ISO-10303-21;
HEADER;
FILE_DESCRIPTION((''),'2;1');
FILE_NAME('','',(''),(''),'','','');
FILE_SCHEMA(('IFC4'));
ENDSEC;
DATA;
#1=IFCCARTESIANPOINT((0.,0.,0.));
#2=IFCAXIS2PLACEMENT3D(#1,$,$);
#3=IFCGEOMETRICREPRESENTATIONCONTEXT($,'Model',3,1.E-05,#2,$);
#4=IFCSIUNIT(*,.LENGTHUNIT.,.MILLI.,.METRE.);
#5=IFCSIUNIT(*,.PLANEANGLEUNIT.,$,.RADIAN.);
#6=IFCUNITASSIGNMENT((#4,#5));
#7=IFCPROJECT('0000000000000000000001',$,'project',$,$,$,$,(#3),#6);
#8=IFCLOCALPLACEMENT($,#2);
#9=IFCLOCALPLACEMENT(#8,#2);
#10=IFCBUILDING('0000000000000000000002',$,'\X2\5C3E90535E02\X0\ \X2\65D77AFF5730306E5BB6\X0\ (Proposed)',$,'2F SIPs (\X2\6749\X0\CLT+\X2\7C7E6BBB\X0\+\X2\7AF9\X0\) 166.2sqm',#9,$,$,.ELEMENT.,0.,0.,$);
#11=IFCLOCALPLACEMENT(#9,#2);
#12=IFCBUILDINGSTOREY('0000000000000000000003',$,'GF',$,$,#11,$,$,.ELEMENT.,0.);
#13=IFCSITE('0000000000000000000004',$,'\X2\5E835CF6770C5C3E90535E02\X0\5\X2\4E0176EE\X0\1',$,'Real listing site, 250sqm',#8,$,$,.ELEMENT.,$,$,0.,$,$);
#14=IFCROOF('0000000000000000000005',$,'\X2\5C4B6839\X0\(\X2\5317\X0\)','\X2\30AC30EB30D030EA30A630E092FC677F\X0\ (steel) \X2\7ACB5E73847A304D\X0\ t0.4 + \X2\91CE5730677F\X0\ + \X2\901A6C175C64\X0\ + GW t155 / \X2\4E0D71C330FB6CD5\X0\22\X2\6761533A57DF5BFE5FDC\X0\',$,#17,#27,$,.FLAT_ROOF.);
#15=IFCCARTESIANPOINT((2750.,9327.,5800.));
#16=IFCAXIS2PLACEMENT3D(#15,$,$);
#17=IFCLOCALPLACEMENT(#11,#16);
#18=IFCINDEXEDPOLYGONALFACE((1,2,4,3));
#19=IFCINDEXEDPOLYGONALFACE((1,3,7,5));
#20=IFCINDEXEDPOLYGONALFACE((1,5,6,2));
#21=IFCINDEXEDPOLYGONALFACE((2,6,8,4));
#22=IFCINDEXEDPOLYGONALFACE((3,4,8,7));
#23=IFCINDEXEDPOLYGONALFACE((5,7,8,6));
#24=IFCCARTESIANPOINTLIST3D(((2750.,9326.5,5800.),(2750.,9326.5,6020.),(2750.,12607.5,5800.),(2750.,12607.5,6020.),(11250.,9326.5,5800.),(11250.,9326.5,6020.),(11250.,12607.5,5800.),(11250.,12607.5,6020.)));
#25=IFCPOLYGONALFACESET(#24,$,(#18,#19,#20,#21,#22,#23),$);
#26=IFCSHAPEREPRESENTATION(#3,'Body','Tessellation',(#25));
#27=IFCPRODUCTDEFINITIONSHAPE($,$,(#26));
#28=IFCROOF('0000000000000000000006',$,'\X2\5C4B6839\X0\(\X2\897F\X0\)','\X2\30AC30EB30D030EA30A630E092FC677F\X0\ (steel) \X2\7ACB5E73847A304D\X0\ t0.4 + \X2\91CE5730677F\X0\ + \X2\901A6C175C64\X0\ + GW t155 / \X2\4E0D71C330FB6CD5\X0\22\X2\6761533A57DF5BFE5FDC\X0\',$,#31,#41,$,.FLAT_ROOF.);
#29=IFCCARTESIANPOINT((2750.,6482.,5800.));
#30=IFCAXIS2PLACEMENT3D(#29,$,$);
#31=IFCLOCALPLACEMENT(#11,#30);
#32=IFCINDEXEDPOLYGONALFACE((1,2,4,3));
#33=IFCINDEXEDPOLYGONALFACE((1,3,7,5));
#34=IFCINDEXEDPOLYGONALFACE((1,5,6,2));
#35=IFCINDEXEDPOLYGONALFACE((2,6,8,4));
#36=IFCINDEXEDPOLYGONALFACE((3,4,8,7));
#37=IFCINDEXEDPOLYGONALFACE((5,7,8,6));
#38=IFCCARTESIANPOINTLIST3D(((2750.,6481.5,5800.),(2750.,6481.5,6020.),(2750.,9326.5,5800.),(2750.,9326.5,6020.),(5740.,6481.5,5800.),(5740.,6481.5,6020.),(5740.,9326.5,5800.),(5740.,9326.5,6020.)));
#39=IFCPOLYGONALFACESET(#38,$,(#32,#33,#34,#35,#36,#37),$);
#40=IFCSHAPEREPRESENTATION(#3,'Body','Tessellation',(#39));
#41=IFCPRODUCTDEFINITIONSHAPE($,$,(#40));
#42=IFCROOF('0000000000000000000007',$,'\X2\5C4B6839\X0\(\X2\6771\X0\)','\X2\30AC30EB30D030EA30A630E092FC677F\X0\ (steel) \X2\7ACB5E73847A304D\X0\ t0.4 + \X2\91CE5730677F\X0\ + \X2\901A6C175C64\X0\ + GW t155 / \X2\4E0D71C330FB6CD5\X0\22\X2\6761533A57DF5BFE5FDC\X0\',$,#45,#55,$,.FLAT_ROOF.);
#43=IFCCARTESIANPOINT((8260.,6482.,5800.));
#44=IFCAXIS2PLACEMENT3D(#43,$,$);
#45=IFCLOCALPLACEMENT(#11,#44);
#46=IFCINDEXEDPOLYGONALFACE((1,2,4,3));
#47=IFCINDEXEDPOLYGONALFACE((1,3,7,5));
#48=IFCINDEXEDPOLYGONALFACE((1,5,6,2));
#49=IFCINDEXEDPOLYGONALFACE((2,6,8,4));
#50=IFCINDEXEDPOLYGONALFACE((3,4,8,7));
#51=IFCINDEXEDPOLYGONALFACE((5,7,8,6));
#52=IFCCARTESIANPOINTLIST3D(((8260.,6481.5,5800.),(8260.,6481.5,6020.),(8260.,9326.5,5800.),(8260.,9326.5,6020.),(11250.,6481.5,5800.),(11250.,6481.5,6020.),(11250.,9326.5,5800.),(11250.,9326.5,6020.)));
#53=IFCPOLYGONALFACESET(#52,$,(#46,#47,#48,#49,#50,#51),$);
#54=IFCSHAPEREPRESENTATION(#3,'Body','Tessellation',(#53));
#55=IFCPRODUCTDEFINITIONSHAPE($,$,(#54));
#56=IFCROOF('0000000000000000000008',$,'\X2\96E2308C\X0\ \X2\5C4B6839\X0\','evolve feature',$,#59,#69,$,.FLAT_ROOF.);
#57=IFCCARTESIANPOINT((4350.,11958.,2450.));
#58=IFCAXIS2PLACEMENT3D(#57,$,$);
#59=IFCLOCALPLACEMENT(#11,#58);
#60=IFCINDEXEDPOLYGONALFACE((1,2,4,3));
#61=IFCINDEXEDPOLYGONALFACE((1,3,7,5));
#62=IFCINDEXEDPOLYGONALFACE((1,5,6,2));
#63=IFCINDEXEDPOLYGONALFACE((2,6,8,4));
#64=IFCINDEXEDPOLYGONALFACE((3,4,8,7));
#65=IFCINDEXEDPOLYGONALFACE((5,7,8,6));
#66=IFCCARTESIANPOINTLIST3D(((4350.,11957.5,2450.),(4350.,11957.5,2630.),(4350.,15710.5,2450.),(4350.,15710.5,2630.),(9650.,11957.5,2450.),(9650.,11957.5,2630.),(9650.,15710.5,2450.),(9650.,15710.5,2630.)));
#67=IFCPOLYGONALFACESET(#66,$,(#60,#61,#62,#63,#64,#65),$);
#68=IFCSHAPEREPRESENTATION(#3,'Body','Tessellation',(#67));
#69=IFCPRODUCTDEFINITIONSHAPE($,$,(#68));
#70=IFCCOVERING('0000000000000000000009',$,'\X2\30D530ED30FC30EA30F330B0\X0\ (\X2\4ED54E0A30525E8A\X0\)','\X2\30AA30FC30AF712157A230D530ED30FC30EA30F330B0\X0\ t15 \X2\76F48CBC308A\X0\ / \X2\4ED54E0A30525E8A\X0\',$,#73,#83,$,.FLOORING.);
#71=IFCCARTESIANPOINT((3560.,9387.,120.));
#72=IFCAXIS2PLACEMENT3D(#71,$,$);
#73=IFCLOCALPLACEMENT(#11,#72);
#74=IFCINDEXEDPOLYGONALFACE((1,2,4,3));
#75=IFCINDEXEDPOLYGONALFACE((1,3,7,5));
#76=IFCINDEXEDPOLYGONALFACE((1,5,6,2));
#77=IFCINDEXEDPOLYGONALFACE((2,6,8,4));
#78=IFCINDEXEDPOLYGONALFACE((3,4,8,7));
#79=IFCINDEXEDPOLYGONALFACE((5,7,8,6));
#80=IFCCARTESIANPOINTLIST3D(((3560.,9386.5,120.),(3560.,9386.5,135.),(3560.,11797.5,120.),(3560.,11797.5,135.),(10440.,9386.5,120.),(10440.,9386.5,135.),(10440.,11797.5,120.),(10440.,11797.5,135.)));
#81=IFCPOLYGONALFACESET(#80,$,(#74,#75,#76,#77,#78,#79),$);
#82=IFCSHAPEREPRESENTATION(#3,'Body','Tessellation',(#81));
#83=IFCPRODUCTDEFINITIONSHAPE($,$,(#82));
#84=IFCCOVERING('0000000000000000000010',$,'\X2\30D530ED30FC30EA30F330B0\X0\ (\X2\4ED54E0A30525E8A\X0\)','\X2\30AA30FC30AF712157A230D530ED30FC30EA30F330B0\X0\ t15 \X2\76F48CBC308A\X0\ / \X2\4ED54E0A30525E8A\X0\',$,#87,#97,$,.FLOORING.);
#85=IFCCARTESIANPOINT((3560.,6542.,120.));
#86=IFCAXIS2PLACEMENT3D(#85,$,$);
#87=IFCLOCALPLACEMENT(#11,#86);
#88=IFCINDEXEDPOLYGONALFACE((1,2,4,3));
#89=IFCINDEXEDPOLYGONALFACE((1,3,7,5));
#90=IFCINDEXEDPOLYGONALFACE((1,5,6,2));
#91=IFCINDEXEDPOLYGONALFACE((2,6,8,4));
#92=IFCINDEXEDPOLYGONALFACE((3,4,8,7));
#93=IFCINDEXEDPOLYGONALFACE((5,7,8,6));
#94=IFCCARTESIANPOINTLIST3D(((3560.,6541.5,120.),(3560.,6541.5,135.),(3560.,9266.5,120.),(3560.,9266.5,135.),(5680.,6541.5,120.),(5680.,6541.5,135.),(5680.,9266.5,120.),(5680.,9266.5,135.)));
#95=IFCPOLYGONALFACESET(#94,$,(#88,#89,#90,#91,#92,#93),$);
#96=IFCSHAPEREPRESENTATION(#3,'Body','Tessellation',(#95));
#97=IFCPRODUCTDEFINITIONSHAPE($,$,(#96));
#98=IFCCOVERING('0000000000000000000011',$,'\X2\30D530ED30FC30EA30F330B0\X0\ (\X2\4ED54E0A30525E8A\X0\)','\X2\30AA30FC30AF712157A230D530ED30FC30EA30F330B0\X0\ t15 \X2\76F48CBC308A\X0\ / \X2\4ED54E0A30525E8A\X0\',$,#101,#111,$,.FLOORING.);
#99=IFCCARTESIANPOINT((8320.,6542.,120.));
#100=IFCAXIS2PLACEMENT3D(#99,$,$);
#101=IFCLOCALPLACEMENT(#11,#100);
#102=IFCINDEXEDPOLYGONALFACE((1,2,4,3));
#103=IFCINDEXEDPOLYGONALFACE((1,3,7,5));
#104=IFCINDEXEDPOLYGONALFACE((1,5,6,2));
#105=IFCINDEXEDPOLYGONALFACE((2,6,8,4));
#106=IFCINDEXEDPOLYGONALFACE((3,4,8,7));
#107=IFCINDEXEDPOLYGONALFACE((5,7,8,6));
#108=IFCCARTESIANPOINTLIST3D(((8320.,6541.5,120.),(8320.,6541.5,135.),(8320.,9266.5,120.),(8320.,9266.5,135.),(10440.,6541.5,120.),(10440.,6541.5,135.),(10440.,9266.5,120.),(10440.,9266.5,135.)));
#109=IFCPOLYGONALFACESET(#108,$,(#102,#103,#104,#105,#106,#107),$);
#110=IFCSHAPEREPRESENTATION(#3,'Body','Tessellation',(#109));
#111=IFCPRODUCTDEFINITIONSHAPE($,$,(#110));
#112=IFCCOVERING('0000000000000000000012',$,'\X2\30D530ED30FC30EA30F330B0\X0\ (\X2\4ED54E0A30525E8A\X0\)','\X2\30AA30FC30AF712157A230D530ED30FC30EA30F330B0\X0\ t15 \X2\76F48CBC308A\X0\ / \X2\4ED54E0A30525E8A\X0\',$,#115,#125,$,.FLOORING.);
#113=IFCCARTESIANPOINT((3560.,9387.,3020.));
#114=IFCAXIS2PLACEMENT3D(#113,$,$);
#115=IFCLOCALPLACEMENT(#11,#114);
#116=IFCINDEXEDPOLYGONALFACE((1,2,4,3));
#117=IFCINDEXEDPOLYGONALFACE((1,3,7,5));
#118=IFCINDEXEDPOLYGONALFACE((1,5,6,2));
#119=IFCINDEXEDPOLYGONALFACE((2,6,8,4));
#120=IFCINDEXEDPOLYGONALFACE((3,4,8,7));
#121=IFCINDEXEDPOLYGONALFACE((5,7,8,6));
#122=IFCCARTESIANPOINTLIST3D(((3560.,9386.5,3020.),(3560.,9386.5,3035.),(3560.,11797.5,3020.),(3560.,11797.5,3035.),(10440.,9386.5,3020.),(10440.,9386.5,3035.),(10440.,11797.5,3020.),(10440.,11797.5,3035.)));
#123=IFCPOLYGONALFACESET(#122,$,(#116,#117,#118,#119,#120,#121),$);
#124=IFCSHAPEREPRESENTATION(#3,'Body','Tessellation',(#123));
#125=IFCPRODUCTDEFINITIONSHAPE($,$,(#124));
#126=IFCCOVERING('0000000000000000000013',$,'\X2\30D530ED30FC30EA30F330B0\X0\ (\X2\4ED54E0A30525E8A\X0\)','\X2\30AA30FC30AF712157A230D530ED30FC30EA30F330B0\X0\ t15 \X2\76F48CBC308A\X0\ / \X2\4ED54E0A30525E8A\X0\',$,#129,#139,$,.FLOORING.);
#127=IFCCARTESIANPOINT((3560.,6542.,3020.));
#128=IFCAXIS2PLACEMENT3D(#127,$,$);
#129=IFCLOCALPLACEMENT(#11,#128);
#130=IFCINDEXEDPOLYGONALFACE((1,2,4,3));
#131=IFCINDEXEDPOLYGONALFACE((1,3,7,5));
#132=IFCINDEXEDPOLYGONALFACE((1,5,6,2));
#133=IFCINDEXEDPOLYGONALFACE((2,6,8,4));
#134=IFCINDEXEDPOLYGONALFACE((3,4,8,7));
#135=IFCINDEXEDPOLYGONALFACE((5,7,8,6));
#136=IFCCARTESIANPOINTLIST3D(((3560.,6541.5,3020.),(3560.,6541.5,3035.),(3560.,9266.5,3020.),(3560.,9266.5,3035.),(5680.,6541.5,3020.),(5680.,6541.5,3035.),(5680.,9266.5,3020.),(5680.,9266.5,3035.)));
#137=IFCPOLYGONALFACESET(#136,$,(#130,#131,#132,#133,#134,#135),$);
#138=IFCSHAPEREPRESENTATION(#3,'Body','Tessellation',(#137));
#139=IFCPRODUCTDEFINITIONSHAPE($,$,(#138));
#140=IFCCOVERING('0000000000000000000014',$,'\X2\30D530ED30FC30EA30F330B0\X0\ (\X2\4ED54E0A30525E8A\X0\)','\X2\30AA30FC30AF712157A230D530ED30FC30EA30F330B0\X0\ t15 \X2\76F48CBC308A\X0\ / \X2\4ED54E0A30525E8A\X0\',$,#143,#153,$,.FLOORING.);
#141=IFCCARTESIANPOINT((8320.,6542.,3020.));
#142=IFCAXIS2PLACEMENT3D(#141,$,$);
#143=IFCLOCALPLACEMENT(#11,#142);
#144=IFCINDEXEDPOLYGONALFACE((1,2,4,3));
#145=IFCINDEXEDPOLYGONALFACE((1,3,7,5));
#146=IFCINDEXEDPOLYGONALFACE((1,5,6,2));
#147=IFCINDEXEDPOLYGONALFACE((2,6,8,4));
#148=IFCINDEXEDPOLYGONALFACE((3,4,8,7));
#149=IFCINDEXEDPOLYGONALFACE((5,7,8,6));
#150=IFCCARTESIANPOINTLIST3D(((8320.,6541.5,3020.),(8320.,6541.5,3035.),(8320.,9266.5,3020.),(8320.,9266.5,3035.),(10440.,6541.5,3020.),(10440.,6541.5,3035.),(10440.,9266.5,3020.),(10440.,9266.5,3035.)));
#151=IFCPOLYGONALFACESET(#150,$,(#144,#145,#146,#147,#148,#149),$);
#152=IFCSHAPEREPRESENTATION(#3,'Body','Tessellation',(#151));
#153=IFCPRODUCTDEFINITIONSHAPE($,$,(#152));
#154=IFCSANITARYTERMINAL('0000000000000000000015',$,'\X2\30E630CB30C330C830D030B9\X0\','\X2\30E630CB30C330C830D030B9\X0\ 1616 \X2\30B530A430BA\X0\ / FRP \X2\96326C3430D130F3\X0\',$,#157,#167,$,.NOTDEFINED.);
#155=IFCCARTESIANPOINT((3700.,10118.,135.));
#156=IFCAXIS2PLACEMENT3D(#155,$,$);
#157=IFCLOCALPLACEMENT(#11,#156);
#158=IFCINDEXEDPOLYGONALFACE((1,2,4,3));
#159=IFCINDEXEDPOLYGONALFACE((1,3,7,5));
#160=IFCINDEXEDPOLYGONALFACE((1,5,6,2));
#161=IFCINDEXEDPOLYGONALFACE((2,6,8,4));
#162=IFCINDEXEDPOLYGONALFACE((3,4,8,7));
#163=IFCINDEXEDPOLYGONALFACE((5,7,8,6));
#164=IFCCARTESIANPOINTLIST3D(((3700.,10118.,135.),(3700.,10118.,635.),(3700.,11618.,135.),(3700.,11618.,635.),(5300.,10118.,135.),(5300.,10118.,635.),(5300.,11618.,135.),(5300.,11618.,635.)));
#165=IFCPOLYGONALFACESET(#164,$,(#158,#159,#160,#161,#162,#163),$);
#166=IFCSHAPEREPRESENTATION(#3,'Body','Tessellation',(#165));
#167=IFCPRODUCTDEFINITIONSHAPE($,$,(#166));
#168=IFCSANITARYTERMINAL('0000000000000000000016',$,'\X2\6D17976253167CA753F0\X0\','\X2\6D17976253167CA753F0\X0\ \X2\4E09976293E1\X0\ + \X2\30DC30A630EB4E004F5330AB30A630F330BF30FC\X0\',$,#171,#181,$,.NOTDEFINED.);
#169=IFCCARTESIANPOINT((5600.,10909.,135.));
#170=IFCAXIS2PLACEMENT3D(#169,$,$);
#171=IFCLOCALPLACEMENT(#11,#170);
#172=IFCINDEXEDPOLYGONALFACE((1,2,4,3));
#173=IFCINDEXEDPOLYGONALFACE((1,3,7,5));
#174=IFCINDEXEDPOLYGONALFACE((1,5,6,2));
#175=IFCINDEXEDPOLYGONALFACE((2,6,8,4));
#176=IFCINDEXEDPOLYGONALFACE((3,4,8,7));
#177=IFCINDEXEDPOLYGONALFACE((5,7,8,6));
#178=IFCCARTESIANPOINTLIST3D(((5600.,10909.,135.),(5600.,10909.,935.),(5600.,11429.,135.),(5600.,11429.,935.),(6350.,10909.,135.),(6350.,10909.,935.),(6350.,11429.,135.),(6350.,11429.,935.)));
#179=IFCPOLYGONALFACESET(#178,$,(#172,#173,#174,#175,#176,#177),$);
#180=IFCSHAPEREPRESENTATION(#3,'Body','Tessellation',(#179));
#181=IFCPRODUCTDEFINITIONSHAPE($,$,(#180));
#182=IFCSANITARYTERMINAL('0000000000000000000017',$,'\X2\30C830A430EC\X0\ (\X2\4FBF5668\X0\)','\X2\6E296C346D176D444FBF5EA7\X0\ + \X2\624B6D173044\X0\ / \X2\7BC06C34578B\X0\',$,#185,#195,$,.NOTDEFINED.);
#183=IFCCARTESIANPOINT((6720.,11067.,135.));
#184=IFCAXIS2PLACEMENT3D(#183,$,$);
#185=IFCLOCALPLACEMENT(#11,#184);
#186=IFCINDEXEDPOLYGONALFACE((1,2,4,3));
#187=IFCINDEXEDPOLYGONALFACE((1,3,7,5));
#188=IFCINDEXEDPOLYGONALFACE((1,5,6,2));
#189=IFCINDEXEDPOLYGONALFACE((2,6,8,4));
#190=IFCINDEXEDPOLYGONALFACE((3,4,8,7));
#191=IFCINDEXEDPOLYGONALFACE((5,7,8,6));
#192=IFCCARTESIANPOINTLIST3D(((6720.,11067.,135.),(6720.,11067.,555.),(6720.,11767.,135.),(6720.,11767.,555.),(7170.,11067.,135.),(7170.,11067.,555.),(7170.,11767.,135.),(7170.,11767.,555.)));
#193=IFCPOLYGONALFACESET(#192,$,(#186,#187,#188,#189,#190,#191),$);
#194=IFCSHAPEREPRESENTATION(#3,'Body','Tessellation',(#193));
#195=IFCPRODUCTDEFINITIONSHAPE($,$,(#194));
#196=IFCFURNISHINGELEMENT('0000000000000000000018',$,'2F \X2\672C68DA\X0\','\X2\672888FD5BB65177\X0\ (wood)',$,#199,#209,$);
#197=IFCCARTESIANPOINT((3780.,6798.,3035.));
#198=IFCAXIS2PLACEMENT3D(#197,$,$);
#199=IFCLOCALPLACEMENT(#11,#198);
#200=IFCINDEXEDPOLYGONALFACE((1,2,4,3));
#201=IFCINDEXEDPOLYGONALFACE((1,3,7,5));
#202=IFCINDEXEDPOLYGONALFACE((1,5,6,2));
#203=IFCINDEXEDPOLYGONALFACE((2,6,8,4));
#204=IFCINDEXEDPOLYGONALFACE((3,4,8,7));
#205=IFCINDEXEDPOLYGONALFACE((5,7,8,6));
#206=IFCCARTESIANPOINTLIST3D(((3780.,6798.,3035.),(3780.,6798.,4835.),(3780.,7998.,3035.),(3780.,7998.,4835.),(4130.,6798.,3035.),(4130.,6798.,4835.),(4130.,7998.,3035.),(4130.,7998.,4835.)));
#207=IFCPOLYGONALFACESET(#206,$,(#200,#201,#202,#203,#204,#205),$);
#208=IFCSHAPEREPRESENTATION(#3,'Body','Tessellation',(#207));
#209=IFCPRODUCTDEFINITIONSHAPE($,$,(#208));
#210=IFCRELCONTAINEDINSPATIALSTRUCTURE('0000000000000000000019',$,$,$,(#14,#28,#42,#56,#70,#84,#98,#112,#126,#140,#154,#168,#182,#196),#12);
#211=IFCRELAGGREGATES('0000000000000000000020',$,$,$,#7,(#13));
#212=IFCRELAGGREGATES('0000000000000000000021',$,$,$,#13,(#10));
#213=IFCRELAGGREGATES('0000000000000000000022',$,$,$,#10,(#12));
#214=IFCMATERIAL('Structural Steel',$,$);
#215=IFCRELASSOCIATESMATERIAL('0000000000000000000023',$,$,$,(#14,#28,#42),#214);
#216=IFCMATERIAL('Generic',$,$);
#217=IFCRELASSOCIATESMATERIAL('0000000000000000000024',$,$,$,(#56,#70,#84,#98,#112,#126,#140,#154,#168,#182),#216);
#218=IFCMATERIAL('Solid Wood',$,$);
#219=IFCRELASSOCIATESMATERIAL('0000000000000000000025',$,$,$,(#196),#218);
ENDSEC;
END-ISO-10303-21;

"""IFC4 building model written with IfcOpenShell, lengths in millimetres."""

from ifc_helpers import new_model, si_unit, frame, frame_2d, origin, place, context, project, spatial, rectangle, extrude, material, element, save


model = new_model("IFC4")

# Units and contexts
model_context = context("Model", 3, precision=1e-05, world=origin())
ifc_project = project(units=[si_unit("LENGTHUNIT", "METRE", prefix="MILLI"), si_unit("PLANEANGLEUNIT", "RADIAN")], contexts=[model_context])

# Site, building, storey
site_placement = place(None, origin())
site = spatial("IfcSite", under=ifc_project, at=site_placement, Name="広島県尾道市5丁目1", ObjectType="Real listing site, 250sqm", CompositionType="ELEMENT", RefElevation=0.0)
building_placement = place(site_placement, origin())
building = spatial("IfcBuilding", under=site, at=building_placement, Name="尾道市 旗竿地の家 (Proposed)", ObjectType="2F SIPs (杉CLT+籾殻+竹) 166.2sqm", CompositionType="ELEMENT", ElevationOfRefHeight=0.0, ElevationOfTerrain=0.0)
storey_placement = place(building_placement, origin())
storey = spatial("IfcBuildingStorey", under=building, at=storey_placement, Name="GF", CompositionType="ELEMENT", Elevation=0.0)

# Shared definitions
ifc_material_1 = material(Name="Solid Wood")
ifc_material_2 = material(Name="Generic")

# Roofs
ifc_material_3 = material(Name="Structural Steel")
for number, where, name in (
    (1, (2750.0, 9327.0, 5800.0), "屋根(北)"),
):
    element("IfcRoof", number, at=place(storey_placement, frame(where)), inside=storey, material=ifc_material_3, Name=name, Description="ガルバリウム鋼板 (steel) 立平葺き t0.4 + 野地板 + 通気層 + GW t155 / 不燃・法22条区域対応", PredefinedType="FLAT_ROOF", context=model_context, shape_type="SweptSolid", body=[
        extrude(rectangle(XDim=8500.0, YDim=3281.0, at=frame_2d((4250.0, 1640.0))), frame((2750.0, 9327.0, 5800.0)), (0.0, 0.0, 1.0), 220.0),
    ])
roof_1_placement = place(storey_placement, frame((2750.0, 6482.0, 5800.0)))
element("IfcRoof", 2, at=roof_1_placement, inside=storey, material=ifc_material_3, Name="屋根(西)", Description="ガルバリウム鋼板 (steel) 立平葺き t0.4 + 野地板 + 通気層 + GW t155 / 不燃・法22条区域対応", PredefinedType="FLAT_ROOF", context=model_context, shape_type="SweptSolid", body=[
    extrude(rectangle(XDim=2990.0, YDim=2845.0, at=frame_2d((1495.0, 1422.0))), frame((2750.0, 6482.0, 5800.0)), (0.0, 0.0, 1.0), 220.0),
])
roof_2_placement = place(storey_placement, frame((8260.0, 6482.0, 5800.0)))
element("IfcRoof", 3, at=roof_2_placement, inside=storey, material=ifc_material_3, Name="屋根(東)", Description="ガルバリウム鋼板 (steel) 立平葺き t0.4 + 野地板 + 通気層 + GW t155 / 不燃・法22条区域対応", PredefinedType="FLAT_ROOF", context=model_context, shape_type="SweptSolid", body=[
    extrude(rectangle(XDim=2990.0, YDim=2845.0, at=frame_2d((1495.0, 1422.0))), frame((8260.0, 6482.0, 5800.0)), (0.0, 0.0, 1.0), 220.0),
])
roof_3_placement = place(storey_placement, frame((4350.0, 11958.0, 2450.0)))
element("IfcRoof", 4, at=roof_3_placement, inside=storey, material=ifc_material_2, Name="離れ 屋根", Description="evolve feature", PredefinedType="FLAT_ROOF", context=model_context, shape_type="SweptSolid", body=[
    extrude(rectangle(XDim=5300.0, YDim=3753.0, at=frame_2d((2650.0, 1876.0))), frame((4350.0, 11958.0, 2450.0)), (0.0, 0.0, 1.0), 180.0),
])

# Coverings
covering_1_placement = place(storey_placement, frame((3560.0, 9387.0, 120.0)))
element("IfcCovering", 5, at=covering_1_placement, inside=storey, material=ifc_material_2, Name="フローリング (仕上げ床)", Description="オーク無垢フローリング t15 直貼り / 仕上げ床", PredefinedType="FLOORING", context=model_context, shape_type="SweptSolid", body=[
    extrude(rectangle(XDim=6880.0, YDim=2411.0, at=frame_2d((3440.0, 1205.0))), frame((3560.0, 9387.0, 120.0)), (0.0, 0.0, 1.0), 15.0),
])
covering_2_placement = place(storey_placement, frame((3560.0, 6542.0, 120.0)))
element("IfcCovering", 6, at=covering_2_placement, inside=storey, material=ifc_material_2, Name="フローリング (仕上げ床)", Description="オーク無垢フローリング t15 直貼り / 仕上げ床", PredefinedType="FLOORING", context=model_context, shape_type="SweptSolid", body=[
    extrude(rectangle(XDim=2120.0, YDim=2725.0, at=frame_2d((1060.0, 1362.0))), frame((3560.0, 6542.0, 120.0)), (0.0, 0.0, 1.0), 15.0),
])
covering_3_placement = place(storey_placement, frame((8320.0, 6542.0, 120.0)))
element("IfcCovering", 7, at=covering_3_placement, inside=storey, material=ifc_material_2, Name="フローリング (仕上げ床)", Description="オーク無垢フローリング t15 直貼り / 仕上げ床", PredefinedType="FLOORING", context=model_context, shape_type="SweptSolid", body=[
    extrude(rectangle(XDim=2120.0, YDim=2725.0, at=frame_2d((1060.0, 1362.0))), frame((8320.0, 6542.0, 120.0)), (0.0, 0.0, 1.0), 15.0),
])
covering_4_placement = place(storey_placement, frame((3560.0, 9387.0, 3020.0)))
element("IfcCovering", 8, at=covering_4_placement, inside=storey, material=ifc_material_2, Name="フローリング (仕上げ床)", Description="オーク無垢フローリング t15 直貼り / 仕上げ床", PredefinedType="FLOORING", context=model_context, shape_type="SweptSolid", body=[
    extrude(rectangle(XDim=6880.0, YDim=2411.0, at=frame_2d((3440.0, 1205.0))), frame((3560.0, 9387.0, 3020.0)), (0.0, 0.0, 1.0), 15.0),
])
covering_5_placement = place(storey_placement, frame((3560.0, 6542.0, 3020.0)))
element("IfcCovering", 9, at=covering_5_placement, inside=storey, material=ifc_material_2, Name="フローリング (仕上げ床)", Description="オーク無垢フローリング t15 直貼り / 仕上げ床", PredefinedType="FLOORING", context=model_context, shape_type="SweptSolid", body=[
    extrude(rectangle(XDim=2120.0, YDim=2725.0, at=frame_2d((1060.0, 1362.0))), frame((3560.0, 6542.0, 3020.0)), (0.0, 0.0, 1.0), 15.0),
])
covering_6_placement = place(storey_placement, frame((8320.0, 6542.0, 3020.0)))
element("IfcCovering", 10, at=covering_6_placement, inside=storey, material=ifc_material_2, Name="フローリング (仕上げ床)", Description="オーク無垢フローリング t15 直貼り / 仕上げ床", PredefinedType="FLOORING", context=model_context, shape_type="SweptSolid", body=[
    extrude(rectangle(XDim=2120.0, YDim=2725.0, at=frame_2d((1060.0, 1362.0))), frame((8320.0, 6542.0, 3020.0)), (0.0, 0.0, 1.0), 15.0),
])

# Sanitary terminals
sanitary_terminal_1_placement = place(storey_placement, frame((3700.0, 10118.0, 135.0)))
element("IfcSanitaryTerminal", 11, at=sanitary_terminal_1_placement, inside=storey, material=ifc_material_2, Name="ユニットバス", Description="ユニットバス 1616 サイズ / FRP 防水パン", PredefinedType="NOTDEFINED", context=model_context, shape_type="SweptSolid", body=[
    extrude(rectangle(XDim=1600.0, YDim=1500.0, at=frame_2d((800.0, 750.0))), frame((3700.0, 10118.0, 135.0)), (0.0, 0.0, 1.0), 500.0),
])
sanitary_terminal_2_placement = place(storey_placement, frame((5600.0, 10909.0, 135.0)))
element("IfcSanitaryTerminal", 12, at=sanitary_terminal_2_placement, inside=storey, material=ifc_material_2, Name="洗面化粧台", Description="洗面化粧台 三面鏡 + ボウル一体カウンター", PredefinedType="NOTDEFINED", context=model_context, shape_type="SweptSolid", body=[
    extrude(rectangle(XDim=750.0, YDim=520.0, at=frame_2d((375.0, 260.0))), frame((5600.0, 10909.0, 135.0)), (0.0, 0.0, 1.0), 800.0),
])
sanitary_terminal_3_placement = place(storey_placement, frame((6720.0, 11067.0, 135.0)))
element("IfcSanitaryTerminal", 13, at=sanitary_terminal_3_placement, inside=storey, material=ifc_material_2, Name="トイレ (便器)", Description="温水洗浄便座 + 手洗い / 節水型", PredefinedType="NOTDEFINED", context=model_context, shape_type="SweptSolid", body=[
    extrude(rectangle(XDim=450.0, YDim=700.0, at=frame_2d((225.0, 350.0))), frame((6720.0, 11067.0, 135.0)), (0.0, 0.0, 1.0), 420.0),
])

# Furnishing element
furnishing_placement = place(storey_placement, frame((3780.0, 6798.0, 3035.0)))
element("IfcFurnishingElement", 14, at=furnishing_placement, inside=storey, material=ifc_material_1, Name="2F 本棚", Description="木製家具 (wood)", context=model_context, shape_type="SweptSolid", body=[
    extrude(rectangle(XDim=350.0, YDim=1200.0, at=frame_2d((175.0, 600.0))), frame((3780.0, 6798.0, 3035.0)), (0.0, 0.0, 1.0), 1800.0),
])

save(model, "model.ifc")
